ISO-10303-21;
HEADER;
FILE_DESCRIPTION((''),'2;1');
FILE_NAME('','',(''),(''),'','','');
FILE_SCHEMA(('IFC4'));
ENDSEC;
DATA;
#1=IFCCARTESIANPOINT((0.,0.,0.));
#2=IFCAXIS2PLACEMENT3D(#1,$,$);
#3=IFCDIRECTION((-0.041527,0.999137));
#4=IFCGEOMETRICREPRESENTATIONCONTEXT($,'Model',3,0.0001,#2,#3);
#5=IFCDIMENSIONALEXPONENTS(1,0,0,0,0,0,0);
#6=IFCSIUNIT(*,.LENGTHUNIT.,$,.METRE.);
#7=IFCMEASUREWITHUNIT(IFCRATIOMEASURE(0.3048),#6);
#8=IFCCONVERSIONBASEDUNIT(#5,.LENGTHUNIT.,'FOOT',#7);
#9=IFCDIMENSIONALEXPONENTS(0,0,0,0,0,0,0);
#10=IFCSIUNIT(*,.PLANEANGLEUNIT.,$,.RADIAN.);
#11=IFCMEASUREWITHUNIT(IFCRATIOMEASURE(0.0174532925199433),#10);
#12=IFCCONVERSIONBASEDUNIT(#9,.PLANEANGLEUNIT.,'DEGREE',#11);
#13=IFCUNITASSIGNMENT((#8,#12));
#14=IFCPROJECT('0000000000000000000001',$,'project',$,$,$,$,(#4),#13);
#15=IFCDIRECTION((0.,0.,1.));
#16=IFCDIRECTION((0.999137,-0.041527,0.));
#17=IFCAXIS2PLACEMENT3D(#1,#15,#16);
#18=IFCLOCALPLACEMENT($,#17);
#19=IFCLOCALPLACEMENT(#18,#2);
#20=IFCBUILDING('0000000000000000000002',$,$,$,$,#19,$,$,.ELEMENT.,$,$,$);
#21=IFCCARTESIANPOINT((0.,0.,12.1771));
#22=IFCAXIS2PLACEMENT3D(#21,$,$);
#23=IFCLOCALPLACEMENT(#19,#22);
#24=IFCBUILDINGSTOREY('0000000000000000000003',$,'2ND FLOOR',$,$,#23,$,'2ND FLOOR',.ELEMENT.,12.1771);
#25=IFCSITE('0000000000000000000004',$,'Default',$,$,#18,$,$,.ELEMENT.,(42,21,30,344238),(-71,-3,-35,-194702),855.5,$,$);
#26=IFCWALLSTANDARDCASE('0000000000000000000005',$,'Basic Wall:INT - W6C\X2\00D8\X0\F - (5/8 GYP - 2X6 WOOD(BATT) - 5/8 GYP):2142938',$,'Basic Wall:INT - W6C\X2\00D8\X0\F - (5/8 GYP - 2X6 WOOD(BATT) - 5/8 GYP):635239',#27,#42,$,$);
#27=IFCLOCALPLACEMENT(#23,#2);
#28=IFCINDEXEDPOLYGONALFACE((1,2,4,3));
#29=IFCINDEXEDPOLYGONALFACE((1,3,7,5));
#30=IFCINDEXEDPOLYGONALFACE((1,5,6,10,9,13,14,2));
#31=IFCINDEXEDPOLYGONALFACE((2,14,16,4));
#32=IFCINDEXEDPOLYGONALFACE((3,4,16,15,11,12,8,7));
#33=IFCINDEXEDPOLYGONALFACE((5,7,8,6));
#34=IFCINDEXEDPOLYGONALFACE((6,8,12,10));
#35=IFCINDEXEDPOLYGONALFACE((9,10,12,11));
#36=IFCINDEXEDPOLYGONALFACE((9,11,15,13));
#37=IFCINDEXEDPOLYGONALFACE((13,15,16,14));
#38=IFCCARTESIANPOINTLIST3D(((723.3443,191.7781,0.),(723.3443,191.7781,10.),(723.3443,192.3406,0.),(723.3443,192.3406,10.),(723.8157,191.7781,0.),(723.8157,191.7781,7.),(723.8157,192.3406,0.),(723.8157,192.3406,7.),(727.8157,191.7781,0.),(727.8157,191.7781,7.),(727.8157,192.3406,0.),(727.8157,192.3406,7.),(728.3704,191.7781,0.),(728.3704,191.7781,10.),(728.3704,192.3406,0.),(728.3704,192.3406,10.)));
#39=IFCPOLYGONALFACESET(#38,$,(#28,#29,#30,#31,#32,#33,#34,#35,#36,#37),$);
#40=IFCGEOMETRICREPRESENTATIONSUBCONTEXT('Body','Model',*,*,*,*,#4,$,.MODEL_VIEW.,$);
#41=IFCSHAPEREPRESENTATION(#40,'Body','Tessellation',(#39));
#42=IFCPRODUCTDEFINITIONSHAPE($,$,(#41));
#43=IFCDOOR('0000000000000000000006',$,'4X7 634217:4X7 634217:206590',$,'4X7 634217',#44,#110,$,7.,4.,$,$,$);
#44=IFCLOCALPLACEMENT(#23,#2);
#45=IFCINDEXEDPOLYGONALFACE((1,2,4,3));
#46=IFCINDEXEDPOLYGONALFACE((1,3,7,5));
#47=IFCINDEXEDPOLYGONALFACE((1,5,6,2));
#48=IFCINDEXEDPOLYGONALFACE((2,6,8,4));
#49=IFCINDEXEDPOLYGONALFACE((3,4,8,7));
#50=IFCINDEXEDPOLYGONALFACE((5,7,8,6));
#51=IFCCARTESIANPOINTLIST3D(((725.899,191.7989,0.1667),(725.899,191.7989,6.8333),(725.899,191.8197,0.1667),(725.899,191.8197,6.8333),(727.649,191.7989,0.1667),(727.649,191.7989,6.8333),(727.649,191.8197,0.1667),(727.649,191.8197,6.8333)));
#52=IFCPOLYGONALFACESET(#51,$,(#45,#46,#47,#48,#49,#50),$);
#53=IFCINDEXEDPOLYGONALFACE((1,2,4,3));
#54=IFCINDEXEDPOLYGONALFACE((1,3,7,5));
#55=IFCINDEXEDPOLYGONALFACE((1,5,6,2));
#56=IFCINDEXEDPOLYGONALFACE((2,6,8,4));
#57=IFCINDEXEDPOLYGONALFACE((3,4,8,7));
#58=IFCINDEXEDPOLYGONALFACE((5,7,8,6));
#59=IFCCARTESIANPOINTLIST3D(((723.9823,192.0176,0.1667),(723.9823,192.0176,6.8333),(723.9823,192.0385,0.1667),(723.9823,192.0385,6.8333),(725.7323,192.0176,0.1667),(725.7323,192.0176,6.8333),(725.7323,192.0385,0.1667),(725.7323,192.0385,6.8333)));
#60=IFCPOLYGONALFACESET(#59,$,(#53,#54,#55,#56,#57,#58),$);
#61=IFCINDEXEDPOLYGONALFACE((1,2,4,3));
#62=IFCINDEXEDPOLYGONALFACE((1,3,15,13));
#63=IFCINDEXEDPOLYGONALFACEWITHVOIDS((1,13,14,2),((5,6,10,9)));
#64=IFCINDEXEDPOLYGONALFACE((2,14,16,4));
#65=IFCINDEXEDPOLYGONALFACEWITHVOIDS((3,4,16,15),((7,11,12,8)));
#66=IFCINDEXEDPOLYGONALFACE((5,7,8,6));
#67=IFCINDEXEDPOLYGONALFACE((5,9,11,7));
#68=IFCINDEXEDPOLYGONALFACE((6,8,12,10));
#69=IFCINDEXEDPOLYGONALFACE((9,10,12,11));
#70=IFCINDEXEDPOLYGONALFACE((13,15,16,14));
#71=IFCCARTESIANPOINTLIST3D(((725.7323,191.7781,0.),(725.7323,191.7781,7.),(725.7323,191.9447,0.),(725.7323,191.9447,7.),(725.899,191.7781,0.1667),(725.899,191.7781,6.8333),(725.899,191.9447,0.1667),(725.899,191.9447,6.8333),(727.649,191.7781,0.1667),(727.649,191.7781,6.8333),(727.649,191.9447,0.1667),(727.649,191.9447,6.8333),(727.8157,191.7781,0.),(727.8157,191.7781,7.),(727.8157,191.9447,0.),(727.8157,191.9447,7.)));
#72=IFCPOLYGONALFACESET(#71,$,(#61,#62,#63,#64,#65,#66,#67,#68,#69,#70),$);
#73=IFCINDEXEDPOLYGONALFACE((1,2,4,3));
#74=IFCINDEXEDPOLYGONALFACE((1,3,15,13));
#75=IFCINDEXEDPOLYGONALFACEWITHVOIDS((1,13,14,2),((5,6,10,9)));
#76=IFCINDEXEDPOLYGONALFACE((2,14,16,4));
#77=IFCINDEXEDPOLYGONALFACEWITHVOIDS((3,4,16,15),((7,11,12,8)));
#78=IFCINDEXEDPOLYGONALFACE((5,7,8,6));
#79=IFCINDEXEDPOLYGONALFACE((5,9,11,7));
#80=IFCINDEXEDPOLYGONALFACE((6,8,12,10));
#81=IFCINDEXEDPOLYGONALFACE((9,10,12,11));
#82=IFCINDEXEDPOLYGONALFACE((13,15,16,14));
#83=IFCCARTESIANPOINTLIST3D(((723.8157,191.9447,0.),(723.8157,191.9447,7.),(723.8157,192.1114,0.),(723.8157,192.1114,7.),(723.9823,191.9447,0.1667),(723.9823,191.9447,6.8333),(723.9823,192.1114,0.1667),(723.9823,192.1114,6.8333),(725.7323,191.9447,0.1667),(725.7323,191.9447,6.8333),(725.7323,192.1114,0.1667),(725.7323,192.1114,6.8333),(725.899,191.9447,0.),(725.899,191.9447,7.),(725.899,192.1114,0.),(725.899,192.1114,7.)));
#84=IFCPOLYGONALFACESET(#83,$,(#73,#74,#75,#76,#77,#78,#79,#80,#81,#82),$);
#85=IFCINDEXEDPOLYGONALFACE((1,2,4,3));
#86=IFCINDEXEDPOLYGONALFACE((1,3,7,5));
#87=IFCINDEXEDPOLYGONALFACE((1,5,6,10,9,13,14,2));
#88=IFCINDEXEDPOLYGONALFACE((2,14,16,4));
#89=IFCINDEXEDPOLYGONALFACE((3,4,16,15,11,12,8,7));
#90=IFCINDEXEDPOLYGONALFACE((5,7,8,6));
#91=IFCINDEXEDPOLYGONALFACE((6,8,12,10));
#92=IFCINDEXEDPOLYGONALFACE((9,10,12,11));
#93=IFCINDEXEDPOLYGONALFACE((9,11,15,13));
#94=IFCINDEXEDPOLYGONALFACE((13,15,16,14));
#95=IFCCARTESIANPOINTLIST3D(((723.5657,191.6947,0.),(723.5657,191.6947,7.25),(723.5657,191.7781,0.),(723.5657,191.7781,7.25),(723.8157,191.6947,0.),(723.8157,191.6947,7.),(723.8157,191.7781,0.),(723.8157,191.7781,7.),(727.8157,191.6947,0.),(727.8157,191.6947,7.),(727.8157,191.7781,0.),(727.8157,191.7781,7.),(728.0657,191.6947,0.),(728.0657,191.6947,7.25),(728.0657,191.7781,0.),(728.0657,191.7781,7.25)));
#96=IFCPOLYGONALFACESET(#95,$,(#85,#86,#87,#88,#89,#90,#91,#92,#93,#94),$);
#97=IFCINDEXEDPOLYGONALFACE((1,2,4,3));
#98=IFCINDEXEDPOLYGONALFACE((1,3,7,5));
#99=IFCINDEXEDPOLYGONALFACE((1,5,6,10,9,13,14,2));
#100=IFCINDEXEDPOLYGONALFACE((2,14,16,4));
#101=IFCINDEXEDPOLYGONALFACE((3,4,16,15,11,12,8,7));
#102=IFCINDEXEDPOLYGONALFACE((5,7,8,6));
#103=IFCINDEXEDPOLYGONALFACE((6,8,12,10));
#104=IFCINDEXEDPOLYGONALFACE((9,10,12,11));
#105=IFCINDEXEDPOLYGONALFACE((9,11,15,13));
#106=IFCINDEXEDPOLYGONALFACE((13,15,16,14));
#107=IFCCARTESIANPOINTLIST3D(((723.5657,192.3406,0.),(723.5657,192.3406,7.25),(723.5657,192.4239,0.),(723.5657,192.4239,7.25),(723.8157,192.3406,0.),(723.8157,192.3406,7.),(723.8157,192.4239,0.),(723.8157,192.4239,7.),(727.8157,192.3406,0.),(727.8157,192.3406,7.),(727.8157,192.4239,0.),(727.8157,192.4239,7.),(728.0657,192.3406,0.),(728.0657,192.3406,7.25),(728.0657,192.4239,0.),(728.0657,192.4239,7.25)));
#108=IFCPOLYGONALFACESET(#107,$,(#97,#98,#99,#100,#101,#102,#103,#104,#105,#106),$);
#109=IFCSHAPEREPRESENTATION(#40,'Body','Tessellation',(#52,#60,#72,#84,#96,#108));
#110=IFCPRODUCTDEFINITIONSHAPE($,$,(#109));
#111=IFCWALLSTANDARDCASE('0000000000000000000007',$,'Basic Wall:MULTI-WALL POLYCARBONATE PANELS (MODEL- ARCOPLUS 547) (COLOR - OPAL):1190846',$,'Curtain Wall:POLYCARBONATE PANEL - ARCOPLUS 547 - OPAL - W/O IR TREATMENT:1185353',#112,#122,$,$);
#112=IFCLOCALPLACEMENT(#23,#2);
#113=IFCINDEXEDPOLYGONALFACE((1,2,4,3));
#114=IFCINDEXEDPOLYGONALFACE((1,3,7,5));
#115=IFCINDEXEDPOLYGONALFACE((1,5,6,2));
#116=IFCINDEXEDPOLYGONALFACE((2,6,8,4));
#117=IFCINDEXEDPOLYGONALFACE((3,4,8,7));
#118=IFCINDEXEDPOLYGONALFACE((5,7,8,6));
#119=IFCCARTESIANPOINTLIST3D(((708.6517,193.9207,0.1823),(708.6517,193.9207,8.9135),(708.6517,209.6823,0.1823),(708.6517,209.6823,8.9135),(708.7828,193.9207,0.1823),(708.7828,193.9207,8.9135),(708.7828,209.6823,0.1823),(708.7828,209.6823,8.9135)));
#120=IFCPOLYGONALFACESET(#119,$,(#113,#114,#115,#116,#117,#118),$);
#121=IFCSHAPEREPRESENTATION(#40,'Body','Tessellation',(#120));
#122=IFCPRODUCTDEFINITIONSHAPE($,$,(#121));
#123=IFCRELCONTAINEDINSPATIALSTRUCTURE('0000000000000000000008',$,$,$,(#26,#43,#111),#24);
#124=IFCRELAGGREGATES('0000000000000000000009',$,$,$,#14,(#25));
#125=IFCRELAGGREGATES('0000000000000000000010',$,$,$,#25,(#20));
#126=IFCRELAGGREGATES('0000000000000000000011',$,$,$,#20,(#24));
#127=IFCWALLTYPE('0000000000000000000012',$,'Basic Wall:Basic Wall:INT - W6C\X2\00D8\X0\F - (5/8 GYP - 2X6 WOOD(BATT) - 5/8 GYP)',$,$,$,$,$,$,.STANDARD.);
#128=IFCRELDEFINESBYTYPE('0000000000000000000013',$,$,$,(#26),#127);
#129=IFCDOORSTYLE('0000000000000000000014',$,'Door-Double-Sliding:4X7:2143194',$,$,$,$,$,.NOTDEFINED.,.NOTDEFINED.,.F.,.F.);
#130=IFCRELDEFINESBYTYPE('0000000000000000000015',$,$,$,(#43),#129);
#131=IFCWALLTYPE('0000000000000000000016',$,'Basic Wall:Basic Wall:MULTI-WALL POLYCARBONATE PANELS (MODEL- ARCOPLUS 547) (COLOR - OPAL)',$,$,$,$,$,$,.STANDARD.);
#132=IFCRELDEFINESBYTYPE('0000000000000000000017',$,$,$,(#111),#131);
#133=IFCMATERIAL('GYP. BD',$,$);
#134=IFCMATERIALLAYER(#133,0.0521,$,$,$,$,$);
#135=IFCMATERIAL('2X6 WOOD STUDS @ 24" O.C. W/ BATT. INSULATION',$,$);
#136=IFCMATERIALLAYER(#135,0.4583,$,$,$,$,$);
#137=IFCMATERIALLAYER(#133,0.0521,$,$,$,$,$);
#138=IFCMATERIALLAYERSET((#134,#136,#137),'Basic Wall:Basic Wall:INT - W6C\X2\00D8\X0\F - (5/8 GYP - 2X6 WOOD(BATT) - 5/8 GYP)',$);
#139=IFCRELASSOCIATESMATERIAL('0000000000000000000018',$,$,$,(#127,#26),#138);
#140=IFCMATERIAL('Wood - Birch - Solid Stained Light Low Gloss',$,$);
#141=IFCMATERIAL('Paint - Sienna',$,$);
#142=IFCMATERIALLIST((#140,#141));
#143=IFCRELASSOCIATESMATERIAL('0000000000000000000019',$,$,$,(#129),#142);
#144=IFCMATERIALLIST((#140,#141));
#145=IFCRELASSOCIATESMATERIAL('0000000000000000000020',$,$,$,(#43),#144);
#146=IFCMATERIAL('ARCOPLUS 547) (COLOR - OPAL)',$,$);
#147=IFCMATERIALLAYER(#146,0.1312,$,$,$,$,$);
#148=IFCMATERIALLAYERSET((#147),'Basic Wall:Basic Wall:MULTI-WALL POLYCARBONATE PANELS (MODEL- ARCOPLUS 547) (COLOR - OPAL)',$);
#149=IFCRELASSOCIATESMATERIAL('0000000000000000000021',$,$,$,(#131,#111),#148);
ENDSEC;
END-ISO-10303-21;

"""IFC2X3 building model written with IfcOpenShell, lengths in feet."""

from ifc_helpers import new_model, entity, si_unit, converted_unit, direction, frame, frame_2d, origin, origin_2d_with_axis, place, context, subcontext, project, spatial, polyline, rectangle, outline, extrude, source, transform, mapped, material, material_list, layer, layer_set, layer_usage, type_object, type_shapes, element, fill, save


model = new_model("IFC2X3")

# Units and contexts
model_context = context("Model", 3, precision=0.0001, world=origin(), true_north=direction((-0.041527, 0.999137)))
body_context = subcontext(model_context, "Body", "Model", "MODEL_VIEW")
ifc_project = project(units=[converted_unit("LENGTHUNIT", "FOOT", entity("IfcRatioMeasure", 0.3048), si_unit("LENGTHUNIT", "METRE"), dimensions=[1, 0, 0, 0, 0, 0, 0]), converted_unit("PLANEANGLEUNIT", "DEGREE", entity("IfcRatioMeasure", 0.0174532925199433), si_unit("PLANEANGLEUNIT", "RADIAN"), dimensions=[0, 0, 0, 0, 0, 0, 0])], contexts=[model_context])

# Site, building, storey
site_placement = place(None, frame((0.0, 0.0, 0.0), z_axis=(0.0, 0.0, 1.0), x_axis=(0.999137, -0.041527, 0.0)))
site = spatial("IfcSite", under=ifc_project, at=site_placement, Name="Default", CompositionType="ELEMENT", RefLatitude=(42, 21, 30, 344238), RefLongitude=(-71, -3, -35, -194702), RefElevation=855.5)
building_placement = place(site_placement, origin())
building = spatial("IfcBuilding", under=site, at=building_placement, CompositionType="ELEMENT")
storey_placement = place(building_placement, frame((0.0, 0.0, 12.1771)))
storey = spatial("IfcBuildingStorey", under=building, at=storey_placement, Name="2ND FLOOR", LongName="2ND FLOOR", CompositionType="ELEMENT", Elevation=12.1771)

# Shared definitions
ifc_material_1 = material(Name="GYP. BD")
ifc_layer_1 = layer(ifc_material_1, 0.0521)
ifc_material_2 = material(Name="2X6 WOOD STUDS @ 24\" O.C. W/ BATT. INSULATION")
ifc_layer_2 = layer(ifc_material_2, 0.4583)
ifc_layer_3 = layer(ifc_material_1, 0.0521)
ifc_layer_set_1 = layer_set([ifc_layer_1, ifc_layer_2, ifc_layer_3], Name="Basic Wall:Basic Wall:INT - W6CØF - (5/8 GYP - 2X6 WOOD(BATT) - 5/8 GYP)")
wall_type_1 = type_object("IfcWallType", Name="Basic Wall:Basic Wall:INT - W6CØF - (5/8 GYP - 2X6 WOOD(BATT) - 5/8 GYP)", PredefinedType="STANDARD", material=ifc_layer_set_1)

# Wall, opening, door
ifc_layer_usage_1 = layer_usage(ifc_layer_set_1, "AXIS2", "NEGATIVE", 0.2812)
wall_1_placement = place(storey_placement, frame((728.3704, 192.0593, 0.0), z_axis=(0.0, 0.0, 1.0), x_axis=(-1.0, 0.0, 0.0)))
wall_1 = element("IfcWallStandardCase", 1, at=wall_1_placement, inside=storey, type_object=wall_type_1, material=ifc_layer_usage_1, Name="Basic Wall:INT - W6CØF - (5/8 GYP - 2X6 WOOD(BATT) - 5/8 GYP):2142938", ObjectType="Basic Wall:INT - W6CØF - (5/8 GYP - 2X6 WOOD(BATT) - 5/8 GYP):635239", context=body_context, shape_type="SweptSolid", body=[
    extrude(rectangle(XDim=5.026, YDim=0.5625, at=frame_2d((2.513, 0.0), x_axis=(-1.0, 0.0))), origin(), (0.0, 0.0, 1.0), 10.0),
])
opening_1_placement = place(wall_1_placement, frame((728.3704, 192.0593, 0.0), z_axis=(0.0, 0.0, 1.0), x_axis=(-1.0, 0.0, 0.0)))
opening_1 = element("IfcOpeningElement", 2, at=opening_1_placement, cuts=wall_1, ObjectType="Opening", context=body_context, shape_type="SweptSolid", body=[
    extrude(rectangle(XDim=7.0, YDim=4.0, at=frame_2d((0.0, 0.0), x_axis=(0.0, 1.0))), frame((725.8157, 192.3462, 3.5), z_axis=(0.0, -1.0, 0.0), x_axis=(1.0, 0.0, 0.0)), (0.0, 0.0, 1.0), 0.5738),
])
ifc_material_3 = material(Name="Wood - Birch - Solid Stained Light Low Gloss")
ifc_material_4 = material(Name="Paint - Sienna")
ifc_material_list_1 = material_list([ifc_material_3, ifc_material_4])
ifc_material_list_2 = material_list([ifc_material_3, ifc_material_4])
door_style_1 = type_object("IfcDoorStyle", Name="Door-Double-Sliding:4X7:2143194", ConstructionType="NOTDEFINED", OperationType="NOTDEFINED", ParameterTakesPrecedence=False, Sizeable=False, material=ifc_material_list_2)
shared_shape_1 = source(origin(), body_context, "Body", "SweptSolid", [
    extrude(rectangle(XDim=1.75, YDim=0.0208, at=origin_2d_with_axis()), frame((1.0417, -0.0369, 0.1667), z_axis=(0.0, 0.0, 1.0), x_axis=(-1.0, 0.0, 0.0)), (0.0, 0.0, 1.0), 6.6667),
    extrude(rectangle(XDim=1.75, YDim=0.0208, at=origin_2d_with_axis()), frame((2.9583, -0.2556, 0.1667)), (0.0, 0.0, 1.0), 6.6667),
    extrude(outline(polyline([(-1.0417, -3.5), (1.0417, -3.5), (1.0417, 3.5), (-1.0417, 3.5), (-1.0417, -3.5)]), holes=[polyline([(0.875, 3.3333), (0.875, -3.3333), (-0.875, -3.3333), (-0.875, 3.3333), (0.875, 3.3333)])]), frame((1.0417, -0.1723, 3.5), z_axis=(0.0, 1.0, 0.0), x_axis=(-1.0, 0.0, 0.0)), (0.0, 0.0, 1.0), 0.1667),
    extrude(outline(polyline([(-3.5, -1.0417), (3.5, -1.0417), (3.5, 1.0417), (-3.5, 1.0417), (-3.5, -1.0417)]), holes=[polyline([(3.3333, 0.875), (3.3333, -0.875), (-3.3333, -0.875), (-3.3333, 0.875), (3.3333, 0.875)])]), frame((2.9583, -0.339, 3.5), z_axis=(0.0, 1.0, 0.0), x_axis=(0.0, 0.0, -1.0)), (0.0, 0.0, 1.0), 0.1667),
    extrude(outline(polyline([(-3.5625, -2.0), (-3.5625, -2.25), (3.6875, -2.25), (3.6875, 2.25), (-3.5625, 2.25), (-3.5625, 2.0), (3.4375, 2.0), (3.4375, -2.0), (-3.5625, -2.0)])), frame((2.0, -0.0056, 3.5625), z_axis=(0.0, -1.0, 0.0), x_axis=(0.0, 0.0, 1.0)), (0.0, 0.0, -1.0), 0.0833),
    extrude(outline(polyline([(-2.25, -3.6875), (2.25, -3.6875), (2.25, 3.5625), (2.0, 3.5625), (2.0, -3.4375), (-2.0, -3.4375), (-2.0, 3.5625), (-2.25, 3.5625), (-2.25, -3.6875)])), frame((2.0, -0.6515, 3.5625), z_axis=(0.0, 1.0, 0.0), x_axis=(1.0, 0.0, 0.0)), (0.0, 0.0, 1.0), 0.0833),
])
type_shapes(door_style_1, [shared_shape_1])
door_1_placement = place(opening_1_placement, frame((727.8157, 191.7724, 0.0), z_axis=(0.0, 0.0, 1.0), x_axis=(-1.0, 0.0, 0.0)))
door_1 = element("IfcDoor", 3, at=door_1_placement, inside=storey, type_object=door_style_1, material=ifc_material_list_1, Name="4X7 634217:4X7 634217:206590", ObjectType="4X7 634217", OverallHeight=7.0, OverallWidth=4.0, context=body_context, shape_type="MappedRepresentation", body=[
    mapped(shared_shape_1, transform((0.0, 0.0, 0.0), scale=1.0)),
])
fill(opening_1, door_1)

# Wall
ifc_material_5 = material(Name="ARCOPLUS 547) (COLOR - OPAL)")
ifc_layer_4 = layer(ifc_material_5, 0.1312)
ifc_layer_set_2 = layer_set([ifc_layer_4], Name="Basic Wall:Basic Wall:MULTI-WALL POLYCARBONATE PANELS (MODEL- ARCOPLUS 547) (COLOR - OPAL)")
ifc_layer_usage_2 = layer_usage(ifc_layer_set_2, "AXIS2", "NEGATIVE", 0.0656)
wall_type_2 = type_object("IfcWallType", Name="Basic Wall:Basic Wall:MULTI-WALL POLYCARBONATE PANELS (MODEL- ARCOPLUS 547) (COLOR - OPAL)", PredefinedType="STANDARD", material=ifc_layer_set_2)
wall_2_placement = place(storey_placement, frame((708.7173, 209.6823, 0.1823), z_axis=(0.0, 0.0, 1.0), x_axis=(0.0, -1.0, 0.0)))
element("IfcWallStandardCase", 4, at=wall_2_placement, inside=storey, type_object=wall_type_2, material=ifc_layer_usage_2, Name="Basic Wall:MULTI-WALL POLYCARBONATE PANELS (MODEL- ARCOPLUS 547) (COLOR - OPAL):1190846", ObjectType="Curtain Wall:POLYCARBONATE PANEL - ARCOPLUS 547 - OPAL - W/O IR TREATMENT:1185353", context=body_context, shape_type="SweptSolid", body=[
    extrude(rectangle(XDim=15.7616, YDim=0.1312, at=frame_2d((7.8808, 0.0), x_axis=(-1.0, 0.0))), origin(), (0.0, 0.0, 1.0), 8.7312),
])

save(model, "model.ifc")
